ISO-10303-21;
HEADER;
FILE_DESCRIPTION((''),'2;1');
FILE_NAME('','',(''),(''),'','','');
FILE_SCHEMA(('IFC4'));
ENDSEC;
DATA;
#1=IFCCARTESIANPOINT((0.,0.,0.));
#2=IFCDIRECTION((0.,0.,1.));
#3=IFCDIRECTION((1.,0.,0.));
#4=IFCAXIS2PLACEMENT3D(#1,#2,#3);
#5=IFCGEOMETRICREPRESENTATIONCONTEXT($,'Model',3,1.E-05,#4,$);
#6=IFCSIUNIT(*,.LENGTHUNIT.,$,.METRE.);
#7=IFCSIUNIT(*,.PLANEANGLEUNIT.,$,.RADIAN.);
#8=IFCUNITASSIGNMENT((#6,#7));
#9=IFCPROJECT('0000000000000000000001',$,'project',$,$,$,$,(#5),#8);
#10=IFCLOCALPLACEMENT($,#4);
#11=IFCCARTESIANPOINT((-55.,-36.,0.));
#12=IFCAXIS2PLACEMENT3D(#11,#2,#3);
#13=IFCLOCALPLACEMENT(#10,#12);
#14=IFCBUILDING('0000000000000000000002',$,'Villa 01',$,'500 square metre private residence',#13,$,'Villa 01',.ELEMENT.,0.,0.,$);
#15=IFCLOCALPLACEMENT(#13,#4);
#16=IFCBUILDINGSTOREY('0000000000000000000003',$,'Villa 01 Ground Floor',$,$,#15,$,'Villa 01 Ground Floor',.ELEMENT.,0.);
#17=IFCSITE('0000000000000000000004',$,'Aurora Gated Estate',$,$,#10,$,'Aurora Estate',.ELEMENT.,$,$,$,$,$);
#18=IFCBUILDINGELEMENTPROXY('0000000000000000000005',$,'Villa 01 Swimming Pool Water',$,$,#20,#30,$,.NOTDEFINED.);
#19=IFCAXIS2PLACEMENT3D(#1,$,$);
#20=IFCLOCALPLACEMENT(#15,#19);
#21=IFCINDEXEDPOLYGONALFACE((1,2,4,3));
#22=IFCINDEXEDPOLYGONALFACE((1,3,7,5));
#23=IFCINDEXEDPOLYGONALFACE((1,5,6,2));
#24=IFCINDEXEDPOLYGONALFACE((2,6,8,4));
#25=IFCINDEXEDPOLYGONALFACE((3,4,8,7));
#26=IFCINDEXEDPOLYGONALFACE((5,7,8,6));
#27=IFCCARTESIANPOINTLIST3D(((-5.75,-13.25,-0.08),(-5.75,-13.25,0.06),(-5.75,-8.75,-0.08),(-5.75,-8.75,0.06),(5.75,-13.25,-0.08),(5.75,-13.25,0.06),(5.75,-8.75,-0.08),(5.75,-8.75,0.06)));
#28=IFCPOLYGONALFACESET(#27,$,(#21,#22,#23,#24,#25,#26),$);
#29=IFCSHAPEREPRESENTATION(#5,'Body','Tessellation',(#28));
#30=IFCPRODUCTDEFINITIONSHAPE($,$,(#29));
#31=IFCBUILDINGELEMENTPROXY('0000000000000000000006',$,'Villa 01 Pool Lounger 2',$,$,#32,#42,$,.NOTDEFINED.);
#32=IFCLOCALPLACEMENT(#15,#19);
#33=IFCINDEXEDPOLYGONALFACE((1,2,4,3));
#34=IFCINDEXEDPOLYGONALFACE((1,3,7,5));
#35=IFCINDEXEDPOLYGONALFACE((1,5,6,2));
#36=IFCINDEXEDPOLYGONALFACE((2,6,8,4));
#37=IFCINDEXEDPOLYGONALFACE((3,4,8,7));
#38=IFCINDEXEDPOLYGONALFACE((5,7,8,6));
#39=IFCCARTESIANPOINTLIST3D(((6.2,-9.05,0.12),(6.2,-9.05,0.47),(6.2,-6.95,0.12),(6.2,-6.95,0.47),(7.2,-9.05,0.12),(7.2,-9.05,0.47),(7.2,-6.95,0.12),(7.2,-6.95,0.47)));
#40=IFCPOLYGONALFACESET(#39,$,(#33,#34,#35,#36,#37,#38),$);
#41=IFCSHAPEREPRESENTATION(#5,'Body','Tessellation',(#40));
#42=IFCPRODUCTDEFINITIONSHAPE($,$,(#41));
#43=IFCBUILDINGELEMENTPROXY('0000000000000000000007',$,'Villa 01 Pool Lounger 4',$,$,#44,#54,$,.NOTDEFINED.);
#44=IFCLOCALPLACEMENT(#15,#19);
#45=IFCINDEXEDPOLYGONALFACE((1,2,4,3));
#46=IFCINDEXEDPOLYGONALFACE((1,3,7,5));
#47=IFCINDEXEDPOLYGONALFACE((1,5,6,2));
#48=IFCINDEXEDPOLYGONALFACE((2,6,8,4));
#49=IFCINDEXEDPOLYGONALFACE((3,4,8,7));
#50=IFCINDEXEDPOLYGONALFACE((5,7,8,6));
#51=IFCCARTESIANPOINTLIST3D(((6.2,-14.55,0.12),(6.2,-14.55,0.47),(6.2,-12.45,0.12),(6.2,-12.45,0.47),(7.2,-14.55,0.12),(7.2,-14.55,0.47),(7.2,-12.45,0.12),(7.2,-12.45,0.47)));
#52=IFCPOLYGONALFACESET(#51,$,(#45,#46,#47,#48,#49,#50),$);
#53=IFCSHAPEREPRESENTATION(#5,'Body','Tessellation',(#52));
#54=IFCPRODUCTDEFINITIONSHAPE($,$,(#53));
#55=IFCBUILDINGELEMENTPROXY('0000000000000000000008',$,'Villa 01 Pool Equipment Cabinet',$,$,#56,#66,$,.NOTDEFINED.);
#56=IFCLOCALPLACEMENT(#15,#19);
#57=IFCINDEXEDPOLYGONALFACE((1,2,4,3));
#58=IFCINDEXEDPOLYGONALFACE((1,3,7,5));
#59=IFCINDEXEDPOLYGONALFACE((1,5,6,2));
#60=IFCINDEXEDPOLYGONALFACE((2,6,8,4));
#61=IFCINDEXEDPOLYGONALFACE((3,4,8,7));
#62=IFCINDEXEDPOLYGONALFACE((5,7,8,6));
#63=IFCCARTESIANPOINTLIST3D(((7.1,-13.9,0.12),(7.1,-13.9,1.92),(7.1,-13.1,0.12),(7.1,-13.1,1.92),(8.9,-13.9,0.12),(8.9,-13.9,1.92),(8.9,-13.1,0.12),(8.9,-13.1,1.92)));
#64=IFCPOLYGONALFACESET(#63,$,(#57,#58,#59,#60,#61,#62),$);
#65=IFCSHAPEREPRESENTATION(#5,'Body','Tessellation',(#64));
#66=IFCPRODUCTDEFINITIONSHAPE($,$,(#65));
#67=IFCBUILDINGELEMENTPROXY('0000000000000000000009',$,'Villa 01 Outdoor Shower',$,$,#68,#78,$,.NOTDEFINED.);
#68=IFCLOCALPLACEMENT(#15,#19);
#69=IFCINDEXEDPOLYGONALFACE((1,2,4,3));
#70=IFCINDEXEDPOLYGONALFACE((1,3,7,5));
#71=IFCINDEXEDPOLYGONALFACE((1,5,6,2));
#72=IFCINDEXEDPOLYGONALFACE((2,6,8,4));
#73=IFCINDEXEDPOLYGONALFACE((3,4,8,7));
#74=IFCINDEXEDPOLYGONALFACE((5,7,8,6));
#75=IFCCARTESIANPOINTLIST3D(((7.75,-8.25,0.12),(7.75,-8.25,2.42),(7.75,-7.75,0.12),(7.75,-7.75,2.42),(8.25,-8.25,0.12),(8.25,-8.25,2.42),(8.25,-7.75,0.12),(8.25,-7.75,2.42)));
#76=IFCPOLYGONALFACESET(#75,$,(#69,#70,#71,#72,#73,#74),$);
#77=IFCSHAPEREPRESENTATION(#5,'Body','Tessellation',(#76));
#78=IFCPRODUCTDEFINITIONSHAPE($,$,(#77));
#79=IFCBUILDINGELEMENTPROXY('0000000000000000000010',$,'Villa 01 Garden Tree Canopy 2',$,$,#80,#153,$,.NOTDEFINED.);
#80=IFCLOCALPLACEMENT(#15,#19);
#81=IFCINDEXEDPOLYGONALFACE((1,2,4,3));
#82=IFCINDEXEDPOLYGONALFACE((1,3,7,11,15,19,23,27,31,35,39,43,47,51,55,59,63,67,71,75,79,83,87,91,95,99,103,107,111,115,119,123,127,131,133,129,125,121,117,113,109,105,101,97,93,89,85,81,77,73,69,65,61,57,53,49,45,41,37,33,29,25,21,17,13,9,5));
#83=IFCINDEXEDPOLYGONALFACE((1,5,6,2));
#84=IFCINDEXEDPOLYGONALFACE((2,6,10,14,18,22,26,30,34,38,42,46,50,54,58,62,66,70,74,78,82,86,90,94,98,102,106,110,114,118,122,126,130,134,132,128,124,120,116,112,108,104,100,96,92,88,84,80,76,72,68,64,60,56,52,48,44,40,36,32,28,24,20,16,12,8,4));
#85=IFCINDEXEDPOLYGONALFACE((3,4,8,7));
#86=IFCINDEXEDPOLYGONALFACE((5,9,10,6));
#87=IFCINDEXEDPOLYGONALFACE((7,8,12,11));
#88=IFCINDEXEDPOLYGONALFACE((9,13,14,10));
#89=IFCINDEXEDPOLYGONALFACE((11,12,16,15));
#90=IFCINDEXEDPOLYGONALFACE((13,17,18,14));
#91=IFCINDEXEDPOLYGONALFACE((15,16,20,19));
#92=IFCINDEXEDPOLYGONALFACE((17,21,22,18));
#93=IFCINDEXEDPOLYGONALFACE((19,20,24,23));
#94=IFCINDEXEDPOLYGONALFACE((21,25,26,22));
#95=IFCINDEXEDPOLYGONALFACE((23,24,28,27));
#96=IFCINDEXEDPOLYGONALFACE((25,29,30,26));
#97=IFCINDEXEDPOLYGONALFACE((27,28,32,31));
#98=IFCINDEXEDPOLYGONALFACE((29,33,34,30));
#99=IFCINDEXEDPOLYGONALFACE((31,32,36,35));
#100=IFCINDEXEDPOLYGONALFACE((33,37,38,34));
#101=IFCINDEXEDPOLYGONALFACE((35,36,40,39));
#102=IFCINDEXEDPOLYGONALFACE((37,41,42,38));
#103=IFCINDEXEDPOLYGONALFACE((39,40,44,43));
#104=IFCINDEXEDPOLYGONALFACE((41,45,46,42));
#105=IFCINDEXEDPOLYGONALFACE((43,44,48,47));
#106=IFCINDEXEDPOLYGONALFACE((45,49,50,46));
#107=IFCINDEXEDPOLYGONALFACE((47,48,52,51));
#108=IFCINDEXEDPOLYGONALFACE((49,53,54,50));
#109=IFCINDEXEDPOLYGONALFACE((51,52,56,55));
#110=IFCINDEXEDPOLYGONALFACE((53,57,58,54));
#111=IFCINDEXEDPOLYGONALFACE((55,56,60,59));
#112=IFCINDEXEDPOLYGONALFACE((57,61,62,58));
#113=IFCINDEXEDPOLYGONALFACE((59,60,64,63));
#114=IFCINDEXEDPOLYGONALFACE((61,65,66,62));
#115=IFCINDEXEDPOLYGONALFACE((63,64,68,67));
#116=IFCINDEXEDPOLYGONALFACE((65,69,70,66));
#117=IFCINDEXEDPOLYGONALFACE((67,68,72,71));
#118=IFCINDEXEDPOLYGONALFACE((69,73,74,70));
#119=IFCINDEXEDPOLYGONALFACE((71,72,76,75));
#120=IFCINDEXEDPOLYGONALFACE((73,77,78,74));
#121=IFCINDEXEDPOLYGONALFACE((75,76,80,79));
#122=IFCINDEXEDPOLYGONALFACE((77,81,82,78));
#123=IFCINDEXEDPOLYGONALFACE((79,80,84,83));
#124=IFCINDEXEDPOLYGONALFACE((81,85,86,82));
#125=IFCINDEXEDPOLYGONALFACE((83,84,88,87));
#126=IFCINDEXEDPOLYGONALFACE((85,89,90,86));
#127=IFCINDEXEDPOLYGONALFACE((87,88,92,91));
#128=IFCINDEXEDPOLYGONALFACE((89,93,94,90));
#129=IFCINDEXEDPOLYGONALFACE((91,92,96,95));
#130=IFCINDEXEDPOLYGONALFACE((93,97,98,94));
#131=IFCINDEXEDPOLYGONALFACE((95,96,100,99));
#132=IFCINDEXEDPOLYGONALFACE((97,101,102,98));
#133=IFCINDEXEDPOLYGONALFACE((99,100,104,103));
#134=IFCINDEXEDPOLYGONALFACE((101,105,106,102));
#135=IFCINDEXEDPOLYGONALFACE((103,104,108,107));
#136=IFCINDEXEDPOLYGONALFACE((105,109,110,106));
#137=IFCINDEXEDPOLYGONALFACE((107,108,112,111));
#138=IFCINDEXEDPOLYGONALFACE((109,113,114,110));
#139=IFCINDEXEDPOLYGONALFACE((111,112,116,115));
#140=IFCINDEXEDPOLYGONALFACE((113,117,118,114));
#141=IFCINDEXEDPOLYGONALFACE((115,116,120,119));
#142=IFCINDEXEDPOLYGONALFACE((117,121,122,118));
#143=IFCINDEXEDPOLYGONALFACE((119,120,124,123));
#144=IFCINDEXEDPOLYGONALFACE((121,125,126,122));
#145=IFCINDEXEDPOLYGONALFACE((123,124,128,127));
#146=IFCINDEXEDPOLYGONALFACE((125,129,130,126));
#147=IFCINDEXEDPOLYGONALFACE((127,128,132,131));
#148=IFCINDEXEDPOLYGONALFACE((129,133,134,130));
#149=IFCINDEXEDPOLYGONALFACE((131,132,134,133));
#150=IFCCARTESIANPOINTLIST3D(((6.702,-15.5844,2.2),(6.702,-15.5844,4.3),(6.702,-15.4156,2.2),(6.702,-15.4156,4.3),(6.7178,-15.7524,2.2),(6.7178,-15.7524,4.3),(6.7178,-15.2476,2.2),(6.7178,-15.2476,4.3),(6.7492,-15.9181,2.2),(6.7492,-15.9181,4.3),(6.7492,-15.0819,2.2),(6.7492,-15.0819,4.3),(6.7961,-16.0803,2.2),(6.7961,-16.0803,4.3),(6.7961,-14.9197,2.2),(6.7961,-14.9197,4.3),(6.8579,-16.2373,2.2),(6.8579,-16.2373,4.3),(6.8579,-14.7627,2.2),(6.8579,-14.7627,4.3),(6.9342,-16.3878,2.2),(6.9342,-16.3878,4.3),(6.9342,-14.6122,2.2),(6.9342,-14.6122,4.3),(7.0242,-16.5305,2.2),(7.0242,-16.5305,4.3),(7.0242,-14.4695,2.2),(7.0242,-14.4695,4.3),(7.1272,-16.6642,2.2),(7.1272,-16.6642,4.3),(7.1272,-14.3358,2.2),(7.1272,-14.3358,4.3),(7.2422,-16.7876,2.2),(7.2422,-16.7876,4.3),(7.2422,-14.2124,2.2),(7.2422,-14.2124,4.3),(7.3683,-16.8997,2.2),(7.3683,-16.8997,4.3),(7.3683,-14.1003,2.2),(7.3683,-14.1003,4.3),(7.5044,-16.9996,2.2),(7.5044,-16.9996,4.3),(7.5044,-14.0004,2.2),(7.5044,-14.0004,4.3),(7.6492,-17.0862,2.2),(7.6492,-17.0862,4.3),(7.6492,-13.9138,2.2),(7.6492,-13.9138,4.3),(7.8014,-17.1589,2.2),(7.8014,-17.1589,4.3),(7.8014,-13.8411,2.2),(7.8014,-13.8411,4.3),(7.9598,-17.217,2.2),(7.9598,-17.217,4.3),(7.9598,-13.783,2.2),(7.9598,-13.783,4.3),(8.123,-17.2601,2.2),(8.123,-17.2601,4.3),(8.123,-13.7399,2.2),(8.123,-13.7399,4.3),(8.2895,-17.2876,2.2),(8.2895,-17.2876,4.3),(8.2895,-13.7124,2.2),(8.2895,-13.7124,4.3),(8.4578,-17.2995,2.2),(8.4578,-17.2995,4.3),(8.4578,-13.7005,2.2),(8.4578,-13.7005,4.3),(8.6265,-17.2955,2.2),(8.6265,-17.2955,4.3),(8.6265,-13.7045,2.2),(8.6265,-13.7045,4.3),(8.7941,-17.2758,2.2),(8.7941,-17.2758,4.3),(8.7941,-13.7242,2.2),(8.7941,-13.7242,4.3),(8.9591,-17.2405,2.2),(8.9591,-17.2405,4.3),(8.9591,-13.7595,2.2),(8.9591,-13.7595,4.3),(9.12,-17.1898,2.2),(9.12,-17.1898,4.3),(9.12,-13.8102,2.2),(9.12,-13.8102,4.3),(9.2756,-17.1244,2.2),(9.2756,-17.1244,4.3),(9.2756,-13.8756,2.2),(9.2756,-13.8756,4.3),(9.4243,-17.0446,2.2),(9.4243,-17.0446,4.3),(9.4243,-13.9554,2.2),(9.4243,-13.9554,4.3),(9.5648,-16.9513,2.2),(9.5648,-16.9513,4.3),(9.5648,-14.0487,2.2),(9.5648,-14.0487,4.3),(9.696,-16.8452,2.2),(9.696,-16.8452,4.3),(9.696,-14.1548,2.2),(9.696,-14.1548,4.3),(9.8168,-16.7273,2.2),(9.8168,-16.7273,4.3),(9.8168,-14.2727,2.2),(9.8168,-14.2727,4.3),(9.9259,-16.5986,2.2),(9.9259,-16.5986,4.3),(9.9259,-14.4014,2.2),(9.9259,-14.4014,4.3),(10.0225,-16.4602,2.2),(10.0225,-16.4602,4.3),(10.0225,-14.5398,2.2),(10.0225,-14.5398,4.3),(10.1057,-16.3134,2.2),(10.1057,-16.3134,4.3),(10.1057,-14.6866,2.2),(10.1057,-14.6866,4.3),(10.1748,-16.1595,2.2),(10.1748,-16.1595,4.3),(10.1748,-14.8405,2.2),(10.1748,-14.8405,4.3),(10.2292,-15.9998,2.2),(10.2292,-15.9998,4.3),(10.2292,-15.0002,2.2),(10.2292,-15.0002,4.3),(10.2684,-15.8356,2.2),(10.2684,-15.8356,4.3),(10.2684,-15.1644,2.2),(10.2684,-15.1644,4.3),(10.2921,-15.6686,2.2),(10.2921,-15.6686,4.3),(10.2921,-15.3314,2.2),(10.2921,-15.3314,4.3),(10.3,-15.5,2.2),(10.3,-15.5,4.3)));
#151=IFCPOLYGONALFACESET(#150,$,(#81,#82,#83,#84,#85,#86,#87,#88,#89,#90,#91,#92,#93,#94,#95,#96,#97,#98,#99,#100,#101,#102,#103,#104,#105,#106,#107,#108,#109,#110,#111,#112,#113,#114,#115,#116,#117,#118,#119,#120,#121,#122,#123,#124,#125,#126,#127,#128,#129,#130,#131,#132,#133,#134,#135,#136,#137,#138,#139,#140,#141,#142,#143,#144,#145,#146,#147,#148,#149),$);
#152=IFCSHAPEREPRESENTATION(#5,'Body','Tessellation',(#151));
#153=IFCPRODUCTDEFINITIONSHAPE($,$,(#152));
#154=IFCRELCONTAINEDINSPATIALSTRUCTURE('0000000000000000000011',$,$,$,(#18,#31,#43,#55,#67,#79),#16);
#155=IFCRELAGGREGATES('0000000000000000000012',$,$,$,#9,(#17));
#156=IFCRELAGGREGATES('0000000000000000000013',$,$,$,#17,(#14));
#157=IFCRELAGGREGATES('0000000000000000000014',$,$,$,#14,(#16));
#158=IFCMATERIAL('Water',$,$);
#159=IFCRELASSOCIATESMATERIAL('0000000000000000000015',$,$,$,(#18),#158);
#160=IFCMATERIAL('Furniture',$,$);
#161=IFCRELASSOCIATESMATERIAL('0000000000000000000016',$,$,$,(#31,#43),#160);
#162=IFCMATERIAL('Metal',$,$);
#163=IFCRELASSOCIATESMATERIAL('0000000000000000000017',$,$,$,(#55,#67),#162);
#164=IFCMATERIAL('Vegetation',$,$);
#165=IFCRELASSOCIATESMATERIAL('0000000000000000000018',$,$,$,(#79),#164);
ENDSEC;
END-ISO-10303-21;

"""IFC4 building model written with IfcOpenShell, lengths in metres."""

from ifc_helpers import new_model, si_unit, frame, origin_with_axes, origin_2d_with_axis, place, context, project, spatial, rectangle, circle, extrude, material, element, save


model = new_model("IFC4")

# Units and contexts
model_context = context("Model", 3, precision=1e-05, world=origin_with_axes())
ifc_project = project(units=[si_unit("LENGTHUNIT", "METRE"), si_unit("PLANEANGLEUNIT", "RADIAN")], contexts=[model_context])

# Site, building, storey
site_placement = place(None, origin_with_axes())
site = spatial("IfcSite", under=ifc_project, at=site_placement, Name="Aurora Gated Estate", LongName="Aurora Estate", CompositionType="ELEMENT")
building_placement = place(site_placement, frame((-55.0, -36.0, 0.0), z_axis=(0.0, 0.0, 1.0), x_axis=(1.0, 0.0, 0.0)))
building = spatial("IfcBuilding", under=site, at=building_placement, Name="Villa 01", ObjectType="500 square metre private residence", LongName="Villa 01", CompositionType="ELEMENT", ElevationOfRefHeight=0.0, ElevationOfTerrain=0.0)
storey_placement = place(building_placement, origin_with_axes())
storey = spatial("IfcBuildingStorey", under=building, at=storey_placement, Name="Villa 01 Ground Floor", LongName="Villa 01 Ground Floor", CompositionType="ELEMENT", Elevation=0.0)

# Building element proxies
ifc_material_1 = material(Name="Furniture")
ifc_material_2 = material(Name="Water")
proxy_1_placement = place(storey_placement, frame((0.0, -11.0, -0.08), z_axis=(0.0, 0.0, 1.0), x_axis=(1.0, 0.0, 0.0)))
element("IfcBuildingElementProxy", 1, at=proxy_1_placement, inside=storey, material=ifc_material_2, Name="Villa 01 Swimming Pool Water", PredefinedType="NOTDEFINED", context=model_context, shape_type="SweptSolid", body=[
    extrude(rectangle(XDim=11.5, YDim=4.5, at=origin_2d_with_axis()), origin_with_axes(), (0.0, 0.0, 1.0), 0.14),
])
for number, where, z_axis, x_axis, name in (
    (2, (6.7, -8.0, 0.12), (0.0, 0.0, 1.0), (1.0, 0.0, 0.0), "Villa 01 Pool Lounger 2"),
    (3, (6.7, -13.5, 0.12), (0.0, 0.0, 1.0), (1.0, 0.0, 0.0), "Villa 01 Pool Lounger 4"),
):
    element("IfcBuildingElementProxy", number, at=place(storey_placement, frame(where, z_axis=z_axis, x_axis=x_axis)), inside=storey, material=ifc_material_1, Name=name, PredefinedType="NOTDEFINED", context=model_context, shape_type="SweptSolid", body=[
        extrude(rectangle(XDim=1.0, YDim=2.1, at=origin_2d_with_axis()), origin_with_axes(), (0.0, 0.0, 1.0), 0.35),
    ])
ifc_material_3 = material(Name="Metal")
proxy_2_placement = place(storey_placement, frame((8.0, -13.5, 0.12), z_axis=(0.0, 0.0, 1.0), x_axis=(1.0, 0.0, 0.0)))
element("IfcBuildingElementProxy", 4, at=proxy_2_placement, inside=storey, material=ifc_material_3, Name="Villa 01 Pool Equipment Cabinet", PredefinedType="NOTDEFINED", context=model_context, shape_type="SweptSolid", body=[
    extrude(rectangle(XDim=1.8, YDim=0.8, at=origin_2d_with_axis()), origin_with_axes(), (0.0, 0.0, 1.0), 1.8),
])
proxy_3_placement = place(storey_placement, frame((8.0, -8.0, 0.12), z_axis=(0.0, 0.0, 1.0), x_axis=(1.0, 0.0, 0.0)))
element("IfcBuildingElementProxy", 5, at=proxy_3_placement, inside=storey, material=ifc_material_3, Name="Villa 01 Outdoor Shower", PredefinedType="NOTDEFINED", context=model_context, shape_type="SweptSolid", body=[
    extrude(rectangle(XDim=0.5, YDim=0.5, at=origin_2d_with_axis()), origin_with_axes(), (0.0, 0.0, 1.0), 2.3),
])
ifc_material_4 = material(Name="Vegetation")
proxy_4_placement = place(storey_placement, frame((8.5, -15.5, 2.2), z_axis=(0.0, 0.0, 1.0), x_axis=(1.0, 0.0, 0.0)))
element("IfcBuildingElementProxy", 6, at=proxy_4_placement, inside=storey, material=ifc_material_4, Name="Villa 01 Garden Tree Canopy 2", PredefinedType="NOTDEFINED", context=model_context, shape_type="SweptSolid", body=[
    extrude(circle(Radius=1.8, at=origin_2d_with_axis()), origin_with_axes(), (0.0, 0.0, 1.0), 2.1),
])

save(model, "model.ifc")
